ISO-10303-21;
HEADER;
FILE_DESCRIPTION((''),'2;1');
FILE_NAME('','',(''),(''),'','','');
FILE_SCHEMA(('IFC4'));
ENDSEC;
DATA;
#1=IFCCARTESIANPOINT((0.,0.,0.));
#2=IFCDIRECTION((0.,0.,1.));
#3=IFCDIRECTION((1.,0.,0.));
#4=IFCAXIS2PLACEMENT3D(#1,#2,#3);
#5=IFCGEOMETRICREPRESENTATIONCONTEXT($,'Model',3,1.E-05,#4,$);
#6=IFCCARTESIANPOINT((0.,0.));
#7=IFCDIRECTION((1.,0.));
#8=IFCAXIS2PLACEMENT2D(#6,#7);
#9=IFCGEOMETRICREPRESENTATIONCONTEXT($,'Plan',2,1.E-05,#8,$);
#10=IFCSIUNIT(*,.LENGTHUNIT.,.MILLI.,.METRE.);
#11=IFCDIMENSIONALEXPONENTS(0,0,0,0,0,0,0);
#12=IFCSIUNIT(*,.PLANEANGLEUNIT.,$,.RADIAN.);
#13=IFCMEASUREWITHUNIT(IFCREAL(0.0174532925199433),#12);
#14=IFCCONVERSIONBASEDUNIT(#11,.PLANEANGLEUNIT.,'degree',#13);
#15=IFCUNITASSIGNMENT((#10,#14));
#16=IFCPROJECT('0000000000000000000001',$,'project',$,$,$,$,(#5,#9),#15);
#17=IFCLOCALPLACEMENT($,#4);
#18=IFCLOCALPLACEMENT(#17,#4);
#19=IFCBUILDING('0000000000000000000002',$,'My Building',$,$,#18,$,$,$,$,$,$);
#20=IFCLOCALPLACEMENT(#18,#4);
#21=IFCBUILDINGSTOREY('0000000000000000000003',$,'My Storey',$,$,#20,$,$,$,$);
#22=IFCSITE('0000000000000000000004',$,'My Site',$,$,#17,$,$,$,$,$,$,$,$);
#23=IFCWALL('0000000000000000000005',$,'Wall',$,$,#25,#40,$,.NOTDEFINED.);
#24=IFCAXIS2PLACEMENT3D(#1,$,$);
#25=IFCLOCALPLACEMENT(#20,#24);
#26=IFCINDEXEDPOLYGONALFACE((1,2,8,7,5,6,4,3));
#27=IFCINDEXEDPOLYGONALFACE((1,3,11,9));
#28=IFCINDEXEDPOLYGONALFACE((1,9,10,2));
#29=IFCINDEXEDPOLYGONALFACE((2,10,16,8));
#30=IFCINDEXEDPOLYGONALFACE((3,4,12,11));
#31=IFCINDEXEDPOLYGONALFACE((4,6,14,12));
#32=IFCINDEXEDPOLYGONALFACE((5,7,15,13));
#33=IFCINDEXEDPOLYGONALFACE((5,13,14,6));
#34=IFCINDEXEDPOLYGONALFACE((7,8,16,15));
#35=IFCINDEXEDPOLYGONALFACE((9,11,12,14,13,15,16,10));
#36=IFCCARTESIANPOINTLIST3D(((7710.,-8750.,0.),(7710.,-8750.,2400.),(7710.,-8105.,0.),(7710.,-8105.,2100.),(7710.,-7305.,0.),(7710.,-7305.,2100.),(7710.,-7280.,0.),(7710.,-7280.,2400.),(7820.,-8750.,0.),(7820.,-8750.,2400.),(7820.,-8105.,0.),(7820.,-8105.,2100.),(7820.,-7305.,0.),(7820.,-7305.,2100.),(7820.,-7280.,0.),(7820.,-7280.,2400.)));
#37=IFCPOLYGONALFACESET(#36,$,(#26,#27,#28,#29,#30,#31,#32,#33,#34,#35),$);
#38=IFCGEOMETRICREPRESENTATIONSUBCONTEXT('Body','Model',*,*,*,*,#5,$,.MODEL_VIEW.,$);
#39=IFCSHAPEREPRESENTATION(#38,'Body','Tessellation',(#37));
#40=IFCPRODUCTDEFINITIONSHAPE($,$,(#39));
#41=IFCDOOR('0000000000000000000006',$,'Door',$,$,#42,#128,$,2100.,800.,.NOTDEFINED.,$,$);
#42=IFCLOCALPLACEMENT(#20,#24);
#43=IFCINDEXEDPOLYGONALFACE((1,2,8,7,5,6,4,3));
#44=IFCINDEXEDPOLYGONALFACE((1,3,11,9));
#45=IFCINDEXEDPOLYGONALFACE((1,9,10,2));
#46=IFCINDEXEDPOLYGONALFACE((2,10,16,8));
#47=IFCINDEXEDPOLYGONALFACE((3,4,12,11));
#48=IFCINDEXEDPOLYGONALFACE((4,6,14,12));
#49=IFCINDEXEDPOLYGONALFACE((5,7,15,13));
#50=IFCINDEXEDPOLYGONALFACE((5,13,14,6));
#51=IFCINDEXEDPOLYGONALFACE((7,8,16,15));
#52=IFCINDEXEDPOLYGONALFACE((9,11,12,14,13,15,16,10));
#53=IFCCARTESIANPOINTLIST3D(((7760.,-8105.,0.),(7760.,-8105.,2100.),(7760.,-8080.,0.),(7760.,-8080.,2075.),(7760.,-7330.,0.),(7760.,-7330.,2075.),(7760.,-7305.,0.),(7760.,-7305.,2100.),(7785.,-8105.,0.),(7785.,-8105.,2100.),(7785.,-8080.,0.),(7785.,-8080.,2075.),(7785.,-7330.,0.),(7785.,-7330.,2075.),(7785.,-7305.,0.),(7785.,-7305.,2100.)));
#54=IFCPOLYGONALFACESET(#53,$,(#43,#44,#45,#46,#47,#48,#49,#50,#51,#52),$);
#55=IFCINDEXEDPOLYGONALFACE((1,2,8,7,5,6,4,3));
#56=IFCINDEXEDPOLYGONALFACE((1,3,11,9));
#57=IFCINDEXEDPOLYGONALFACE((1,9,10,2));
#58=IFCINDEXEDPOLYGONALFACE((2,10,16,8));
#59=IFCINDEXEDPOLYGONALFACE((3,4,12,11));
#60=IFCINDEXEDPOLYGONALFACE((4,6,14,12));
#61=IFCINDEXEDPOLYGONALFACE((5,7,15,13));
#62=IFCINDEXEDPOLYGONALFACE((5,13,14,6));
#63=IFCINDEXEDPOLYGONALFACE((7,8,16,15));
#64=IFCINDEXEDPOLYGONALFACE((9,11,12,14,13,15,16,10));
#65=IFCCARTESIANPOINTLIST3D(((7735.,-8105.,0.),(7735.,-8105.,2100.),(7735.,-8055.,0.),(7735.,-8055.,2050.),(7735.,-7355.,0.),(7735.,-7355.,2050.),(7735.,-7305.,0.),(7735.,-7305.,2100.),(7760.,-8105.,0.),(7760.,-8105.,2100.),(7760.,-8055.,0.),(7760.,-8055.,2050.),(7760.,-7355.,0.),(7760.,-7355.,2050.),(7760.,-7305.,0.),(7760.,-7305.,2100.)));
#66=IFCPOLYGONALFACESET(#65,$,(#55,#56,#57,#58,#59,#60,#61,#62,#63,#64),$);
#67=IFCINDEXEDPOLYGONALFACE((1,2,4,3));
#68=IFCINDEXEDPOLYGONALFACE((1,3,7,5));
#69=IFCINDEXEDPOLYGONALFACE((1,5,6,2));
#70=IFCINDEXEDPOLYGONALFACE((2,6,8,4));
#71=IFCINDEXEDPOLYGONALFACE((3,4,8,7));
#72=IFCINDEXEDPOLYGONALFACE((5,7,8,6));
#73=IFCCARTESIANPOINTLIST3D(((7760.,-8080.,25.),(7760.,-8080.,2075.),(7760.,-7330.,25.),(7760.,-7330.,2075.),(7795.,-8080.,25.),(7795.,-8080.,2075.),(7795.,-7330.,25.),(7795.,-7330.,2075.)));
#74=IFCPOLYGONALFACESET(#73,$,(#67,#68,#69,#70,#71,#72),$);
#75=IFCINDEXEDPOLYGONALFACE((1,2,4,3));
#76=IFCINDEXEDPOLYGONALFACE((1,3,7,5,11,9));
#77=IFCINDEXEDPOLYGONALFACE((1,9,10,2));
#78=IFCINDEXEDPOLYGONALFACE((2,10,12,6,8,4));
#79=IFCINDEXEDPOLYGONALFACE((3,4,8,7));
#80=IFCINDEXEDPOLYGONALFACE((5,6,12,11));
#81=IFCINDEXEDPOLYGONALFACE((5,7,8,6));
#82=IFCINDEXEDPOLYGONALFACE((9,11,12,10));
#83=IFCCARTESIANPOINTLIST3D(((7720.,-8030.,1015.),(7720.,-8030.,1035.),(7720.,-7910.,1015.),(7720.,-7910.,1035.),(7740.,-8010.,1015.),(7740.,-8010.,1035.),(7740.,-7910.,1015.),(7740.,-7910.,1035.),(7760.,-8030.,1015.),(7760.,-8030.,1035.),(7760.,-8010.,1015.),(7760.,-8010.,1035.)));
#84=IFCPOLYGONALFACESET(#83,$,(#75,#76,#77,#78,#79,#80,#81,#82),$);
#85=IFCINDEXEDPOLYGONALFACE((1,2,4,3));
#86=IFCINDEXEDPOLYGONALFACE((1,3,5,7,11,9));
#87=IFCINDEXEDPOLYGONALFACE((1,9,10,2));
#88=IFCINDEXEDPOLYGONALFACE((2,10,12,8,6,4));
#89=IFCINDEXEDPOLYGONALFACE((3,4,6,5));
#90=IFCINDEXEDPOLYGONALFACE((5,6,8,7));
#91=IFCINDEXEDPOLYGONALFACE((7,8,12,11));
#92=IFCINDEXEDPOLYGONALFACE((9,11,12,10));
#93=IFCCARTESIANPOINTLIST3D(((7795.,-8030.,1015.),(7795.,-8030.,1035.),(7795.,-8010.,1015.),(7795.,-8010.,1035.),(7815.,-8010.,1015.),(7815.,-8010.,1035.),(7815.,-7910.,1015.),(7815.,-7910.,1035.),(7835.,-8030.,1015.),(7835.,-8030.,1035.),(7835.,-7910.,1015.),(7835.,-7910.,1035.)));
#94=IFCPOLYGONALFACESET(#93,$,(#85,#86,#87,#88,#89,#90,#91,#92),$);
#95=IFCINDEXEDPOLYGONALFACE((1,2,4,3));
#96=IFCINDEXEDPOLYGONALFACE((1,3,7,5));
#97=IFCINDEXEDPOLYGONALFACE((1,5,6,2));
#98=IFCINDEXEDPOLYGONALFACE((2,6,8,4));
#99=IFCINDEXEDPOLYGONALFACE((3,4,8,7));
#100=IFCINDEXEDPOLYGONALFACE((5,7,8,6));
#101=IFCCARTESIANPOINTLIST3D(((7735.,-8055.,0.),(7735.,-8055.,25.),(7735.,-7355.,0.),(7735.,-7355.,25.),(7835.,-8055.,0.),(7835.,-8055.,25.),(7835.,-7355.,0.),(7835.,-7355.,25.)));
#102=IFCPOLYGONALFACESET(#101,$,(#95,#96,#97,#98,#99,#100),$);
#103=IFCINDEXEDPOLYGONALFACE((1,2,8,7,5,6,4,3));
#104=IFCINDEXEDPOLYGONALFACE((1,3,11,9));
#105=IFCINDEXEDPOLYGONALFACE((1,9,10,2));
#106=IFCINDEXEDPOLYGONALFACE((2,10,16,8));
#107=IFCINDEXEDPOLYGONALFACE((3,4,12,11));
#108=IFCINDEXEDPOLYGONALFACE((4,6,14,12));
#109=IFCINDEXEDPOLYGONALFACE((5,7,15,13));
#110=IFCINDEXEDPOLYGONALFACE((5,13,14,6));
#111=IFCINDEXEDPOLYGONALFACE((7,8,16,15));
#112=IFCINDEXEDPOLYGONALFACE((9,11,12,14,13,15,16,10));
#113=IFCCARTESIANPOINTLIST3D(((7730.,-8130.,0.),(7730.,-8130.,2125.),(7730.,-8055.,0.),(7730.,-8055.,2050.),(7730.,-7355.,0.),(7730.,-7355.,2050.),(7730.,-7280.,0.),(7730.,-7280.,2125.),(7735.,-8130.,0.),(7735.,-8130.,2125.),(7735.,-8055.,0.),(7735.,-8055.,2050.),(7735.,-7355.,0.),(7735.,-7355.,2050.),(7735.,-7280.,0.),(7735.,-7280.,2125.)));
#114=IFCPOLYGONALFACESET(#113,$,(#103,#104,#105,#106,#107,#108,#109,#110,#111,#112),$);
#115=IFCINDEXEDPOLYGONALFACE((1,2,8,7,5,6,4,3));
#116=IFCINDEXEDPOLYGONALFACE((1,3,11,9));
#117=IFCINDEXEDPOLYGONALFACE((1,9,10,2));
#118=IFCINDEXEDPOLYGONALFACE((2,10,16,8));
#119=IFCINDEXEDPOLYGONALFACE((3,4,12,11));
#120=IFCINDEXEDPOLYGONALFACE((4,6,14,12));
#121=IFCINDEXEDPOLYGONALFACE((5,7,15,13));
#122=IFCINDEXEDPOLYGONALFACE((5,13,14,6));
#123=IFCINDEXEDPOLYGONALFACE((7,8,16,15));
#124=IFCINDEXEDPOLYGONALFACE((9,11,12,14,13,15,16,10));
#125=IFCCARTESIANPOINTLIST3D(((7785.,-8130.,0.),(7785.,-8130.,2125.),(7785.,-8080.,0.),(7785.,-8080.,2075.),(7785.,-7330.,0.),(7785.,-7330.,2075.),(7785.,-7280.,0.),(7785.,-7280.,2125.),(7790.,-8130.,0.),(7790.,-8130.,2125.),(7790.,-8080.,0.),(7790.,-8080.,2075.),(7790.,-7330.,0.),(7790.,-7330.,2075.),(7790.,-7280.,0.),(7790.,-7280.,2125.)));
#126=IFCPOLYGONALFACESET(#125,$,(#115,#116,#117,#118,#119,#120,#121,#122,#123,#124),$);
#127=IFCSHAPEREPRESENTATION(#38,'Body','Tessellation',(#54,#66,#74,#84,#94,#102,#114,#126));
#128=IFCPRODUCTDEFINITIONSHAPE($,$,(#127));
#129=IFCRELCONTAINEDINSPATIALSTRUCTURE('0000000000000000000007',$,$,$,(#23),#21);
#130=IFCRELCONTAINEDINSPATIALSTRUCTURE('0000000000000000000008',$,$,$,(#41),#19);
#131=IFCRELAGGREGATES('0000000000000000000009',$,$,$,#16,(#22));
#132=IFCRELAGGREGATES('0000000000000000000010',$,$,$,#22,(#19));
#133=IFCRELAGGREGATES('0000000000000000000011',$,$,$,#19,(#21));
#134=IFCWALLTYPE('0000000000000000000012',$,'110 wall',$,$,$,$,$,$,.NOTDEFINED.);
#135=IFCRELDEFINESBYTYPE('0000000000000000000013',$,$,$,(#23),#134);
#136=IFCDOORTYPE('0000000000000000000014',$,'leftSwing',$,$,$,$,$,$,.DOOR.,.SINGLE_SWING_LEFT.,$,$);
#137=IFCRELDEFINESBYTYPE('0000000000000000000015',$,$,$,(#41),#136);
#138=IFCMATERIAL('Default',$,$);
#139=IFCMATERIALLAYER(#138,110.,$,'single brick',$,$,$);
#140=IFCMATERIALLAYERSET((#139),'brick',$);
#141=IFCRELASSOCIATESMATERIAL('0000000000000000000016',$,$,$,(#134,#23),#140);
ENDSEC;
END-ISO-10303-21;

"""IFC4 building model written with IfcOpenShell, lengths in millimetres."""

from ifc_helpers import new_model, entity, si_unit, converted_unit, frame, origin_with_axes, origin_2d_with_axis, place, context, subcontext, project, spatial, line, indexed_curve, outline, extrude, shape, source, transform, mapped, material, layer, layer_set, layer_usage, type_object, type_shapes, element, fill, save


model = new_model("IFC4")

# Units and contexts
model_context = context("Model", 3, precision=1e-05, world=origin_with_axes())
plan_context = context("Plan", 2, precision=1e-05, world=origin_2d_with_axis())
body_context_1 = subcontext(model_context, "Body", "Model", "MODEL_VIEW")
body_context_2 = subcontext(plan_context, "Body", "Plan", "PLAN_VIEW")
ifc_project = project(units=[si_unit("LENGTHUNIT", "METRE", prefix="MILLI"), converted_unit("PLANEANGLEUNIT", "degree", entity("IfcReal", 0.0174532925199433), si_unit("PLANEANGLEUNIT", "RADIAN"), dimensions=[0, 0, 0, 0, 0, 0, 0])], contexts=[model_context, plan_context])

# Site, building, storey
site_placement = place(None, origin_with_axes())
site = spatial("IfcSite", under=ifc_project, at=site_placement, Name="My Site")
building_placement = place(site_placement, origin_with_axes())
building = spatial("IfcBuilding", under=site, at=building_placement, Name="My Building")
storey_placement = place(building_placement, origin_with_axes())
storey = spatial("IfcBuildingStorey", under=building, at=storey_placement, Name="My Storey")

# Shared definitions
ifc_material_1 = material(Name="Default")
ifc_layer_1 = layer(ifc_material_1, 110.0, Name="single brick")
ifc_layer_set_1 = layer_set([ifc_layer_1], Name="brick")
wall_type_1 = type_object("IfcWallType", Name="110 wall", PredefinedType="NOTDEFINED", material=ifc_layer_set_1)

# Wall, opening, door
ifc_layer_usage_1 = layer_usage(ifc_layer_set_1, "AXIS2", "POSITIVE", 0.0)
wall_1_placement = place(storey_placement, frame((7820.0, -8750.0, 0.0), z_axis=(0.0, 0.0, 1.0), x_axis=(0.000001, 1.0, 0.0)))
wall_1 = element("IfcWall", 1, at=wall_1_placement, inside=storey, type_object=wall_type_1, material=ifc_layer_usage_1, Name="Wall", PredefinedType="NOTDEFINED", context=body_context_1, shape_type="SweptSolid", body=[
    extrude(outline(indexed_curve([(0.0, 0.0), (0.0, 110.0), (1470.0, 110.0), (1470.0, 0.0), (0.0, 0.0)], self_intersect=False)), origin_with_axes(), (0.0, 0.0, 1.0), 2400.0),
])
shared_shape_1 = source(origin_with_axes(), body_context_1, "Body", "SweptSolid", [
    extrude(outline(indexed_curve([(0.0, 0.0, 0.0), (800.0, 0.0, 0.0), (800.0, 0.0, 2100.0), (0.0, 0.0, 2100.0)], segments=[line(1, 2), line(2, 3), line(3, 4), line(4, 1)])), frame((0.0, -100.0, 0.0), z_axis=(0.0, 0.0, 1.0), x_axis=(1.0, 0.0, 0.0)), (0.0, 1.0, 0.0), 310.0),
])
opening_1_placement = place(wall_1_placement, frame((1445.0, 85.0, 0.0), z_axis=(0.0, 0.0, 1.0), x_axis=(-1.0, 0.0, 0.0)))
opening_1 = element("IfcOpeningElement", 2, at=opening_1_placement, cuts=wall_1, PredefinedType="OPENING", context=body_context_1, shape_type="MappedRepresentation", body=[
    mapped(shared_shape_1, transform((0.0, 0.0, 0.0), x_axis=(1.0, 0.0, 0.0), y_axis=(0.0, 1.0, 0.0), z_axis=(0.0, 0.0, 1.0), scale=1.0)),
])
door_type_1 = type_object("IfcDoorType", Name="leftSwing", OperationType="SINGLE_SWING_LEFT", PredefinedType="DOOR")
shared_shape_2 = source(origin_with_axes(), body_context_1, "Body", "SweptSolid", [
    extrude(outline(indexed_curve([(0.0, 0.0, 0.0), (0.0, 0.0, 2100.0), (800.0, 0.0, 2100.0), (800.0, 0.0, 0.0), (775.0, 0.0, 0.0), (775.0, 0.0, 2075.0), (25.0, 0.0, 2075.0), (25.0, 0.0, 0.0)], segments=[line(1, 2), line(2, 3), line(3, 4), line(4, 5), line(5, 6), line(6, 7), line(7, 8), line(8, 1)])), frame((0.0, 25.0, 0.0), z_axis=(0.0, 0.0, 1.0), x_axis=(1.0, 0.0, 0.0)), (0.0, 1.0, 0.0), 25.0),
    extrude(outline(indexed_curve([(0.0, 0.0, 0.0), (0.0, 0.0, 2100.0), (800.0, 0.0, 2100.0), (800.0, 0.0, 0.0), (750.0, 0.0, 0.0), (750.0, 0.0, 2050.0), (50.0, 0.0, 2050.0), (50.0, 0.0, 0.0)], segments=[line(1, 2), line(2, 3), line(3, 4), line(4, 5), line(5, 6), line(6, 7), line(7, 8), line(8, 1)])), origin_with_axes(), (0.0, 1.0, 0.0), 25.0),
    extrude(outline(indexed_curve([(0.0, 0.0), (750.0, 0.0), (750.0, 35.0), (0.0, 35.0)], segments=[line(1, 2), line(2, 3), line(3, 4), line(4, 1)])), frame((25.0, 25.0, 25.0), z_axis=(0.0, 0.0, 1.0), x_axis=(1.0, 0.0, 0.0)), (0.0, 0.0, 1.0), 2050.0),
    extrude(outline(indexed_curve([(0.0, 0.0), (0.0, -40.0), (-120.0, -40.0), (-120.0, -20.0), (-20.0, -20.0), (-20.0, 0.0)], segments=[line(1, 2), line(2, 3), line(3, 4), line(4, 5), line(5, 6), line(6, 1)])), frame((725.0, 25.0, 1015.0), z_axis=(0.0, 0.0, 1.0), x_axis=(1.0, 0.0, 0.0)), (0.0, 0.0, 1.0), 20.0),
    extrude(outline(indexed_curve([(0.0, 0.0), (0.0, 40.0), (-120.0, 40.0), (-120.0, 20.0), (-20.0, 20.0), (-20.0, 0.0)], segments=[line(1, 2), line(2, 3), line(3, 4), line(4, 5), line(5, 6), line(6, 1)])), frame((725.0, 60.0, 1015.0), z_axis=(0.0, 0.0, 1.0), x_axis=(1.0, 0.0, 0.0)), (0.0, 0.0, 1.0), 20.0),
    extrude(outline(indexed_curve([(0.0, 0.0), (700.0, 0.0), (700.0, 100.0), (0.0, 100.0)], segments=[line(1, 2), line(2, 3), line(3, 4), line(4, 1)])), frame((50.0, 0.0, 0.0), z_axis=(0.0, 0.0, 1.0), x_axis=(1.0, 0.0, 0.0)), (0.0, 0.0, 1.0), 25.0),
    extrude(outline(indexed_curve([(0.0, 0.0, 0.0), (0.0, 0.0, 2125.0), (850.0, 0.0, 2125.0), (850.0, 0.0, 0.0), (775.0, 0.0, 0.0), (775.0, 0.0, 2050.0), (75.0, 0.0, 2050.0), (75.0, 0.0, 0.0)], segments=[line(1, 2), line(2, 3), line(3, 4), line(4, 5), line(5, 6), line(6, 7), line(7, 8), line(8, 1)])), frame((-25.0, -5.0, 0.0), z_axis=(0.0, 0.0, 1.0), x_axis=(1.0, 0.0, 0.0)), (0.0, 1.0, 0.0), 5.0),
    extrude(outline(indexed_curve([(0.0, 0.0, 0.0), (0.0, 0.0, 2125.0), (850.0, 0.0, 2125.0), (850.0, 0.0, 0.0), (800.0, 0.0, 0.0), (800.0, 0.0, 2075.0), (50.0, 0.0, 2075.0), (50.0, 0.0, 0.0)], segments=[line(1, 2), line(2, 3), line(3, 4), line(4, 5), line(5, 6), line(6, 7), line(7, 8), line(8, 1)])), frame((-25.0, 50.0, 0.0), z_axis=(0.0, 0.0, 1.0), x_axis=(1.0, 0.0, 0.0)), (0.0, 1.0, 0.0), 5.0),
])
shared_shape_3 = source(origin_with_axes(), body_context_2, "Body", "Curve2D", [
    entity("IfcIndexedPolyCurve", entity("IfcCartesianPointList2D", [[0.0, 0.0], [0.0, 50.0], [25.0, 50.0], [25.0, 25.0], [50.0, 25.0], [50.0, 0.0]]), [entity("IfcLineIndex", [1, 2]), entity("IfcLineIndex", [2, 3]), entity("IfcLineIndex", [3, 4]), entity("IfcLineIndex", [4, 5]), entity("IfcLineIndex", [5, 6]), entity("IfcLineIndex", [6, 1])]),
    entity("IfcIndexedPolyCurve", entity("IfcCartesianPointList2D", [[800.0, 0.0], [800.0, 50.0], [775.0, 50.0], [775.0, 25.0], [750.0, 25.0], [750.0, 0.0]]), [entity("IfcLineIndex", [1, 2]), entity("IfcLineIndex", [2, 3]), entity("IfcLineIndex", [3, 4]), entity("IfcLineIndex", [4, 5]), entity("IfcLineIndex", [5, 6]), entity("IfcLineIndex", [6, 1])]),
    entity("IfcTrimmedCurve", entity("IfcEllipse", entity("IfcAxis2Placement2D", entity("IfcCartesianPoint", [60.0, 50.0]), entity("IfcDirection", [1.0, 0.0])), 715.0, 750.0), [entity("IfcCartesianPoint", [775.0, 50.0])], [entity("IfcCartesianPoint", [60.0, 800.0])], True, "CARTESIAN"),
    entity("IfcIndexedPolyCurve", entity("IfcCartesianPointList2D", [[25.0, 50.0], [60.0, 50.0], [60.0, 800.0], [25.0, 800.0]]), [entity("IfcLineIndex", [1, 2]), entity("IfcLineIndex", [2, 3]), entity("IfcLineIndex", [3, 4]), entity("IfcLineIndex", [4, 1])]),
])
type_shapes(door_type_1, [shared_shape_2, shared_shape_3])
door_1_placement = place(building_placement, frame((7735.0, -7305.0, 0.0), z_axis=(0.0, 0.0, 1.0), x_axis=(-0.000001, -1.0, 0.0)))
door_1 = element("IfcDoor", 3, at=door_1_placement, inside=building, type_object=door_type_1, Name="Door", OverallHeight=2100.0, OverallWidth=800.0, PredefinedType="NOTDEFINED", shapes=[
    shape(body_context_1, "Body", "MappedRepresentation", [mapped(shared_shape_2, transform((0.0, 0.0, 0.0), x_axis=(1.0, 0.0, 0.0), y_axis=(0.0, 1.0, 0.0), z_axis=(0.0, 0.0, 1.0), scale=1.0))]),
    shape(body_context_2, "Body", "MappedRepresentation", [mapped(shared_shape_3, transform((0.0, 0.0, 0.0), x_axis=(1.0, 0.0, 0.0), y_axis=(0.0, 1.0, 0.0), z_axis=(0.0, 0.0, 1.0), scale=1.0))]),
])
fill(opening_1, door_1)

save(model, "model.ifc")
